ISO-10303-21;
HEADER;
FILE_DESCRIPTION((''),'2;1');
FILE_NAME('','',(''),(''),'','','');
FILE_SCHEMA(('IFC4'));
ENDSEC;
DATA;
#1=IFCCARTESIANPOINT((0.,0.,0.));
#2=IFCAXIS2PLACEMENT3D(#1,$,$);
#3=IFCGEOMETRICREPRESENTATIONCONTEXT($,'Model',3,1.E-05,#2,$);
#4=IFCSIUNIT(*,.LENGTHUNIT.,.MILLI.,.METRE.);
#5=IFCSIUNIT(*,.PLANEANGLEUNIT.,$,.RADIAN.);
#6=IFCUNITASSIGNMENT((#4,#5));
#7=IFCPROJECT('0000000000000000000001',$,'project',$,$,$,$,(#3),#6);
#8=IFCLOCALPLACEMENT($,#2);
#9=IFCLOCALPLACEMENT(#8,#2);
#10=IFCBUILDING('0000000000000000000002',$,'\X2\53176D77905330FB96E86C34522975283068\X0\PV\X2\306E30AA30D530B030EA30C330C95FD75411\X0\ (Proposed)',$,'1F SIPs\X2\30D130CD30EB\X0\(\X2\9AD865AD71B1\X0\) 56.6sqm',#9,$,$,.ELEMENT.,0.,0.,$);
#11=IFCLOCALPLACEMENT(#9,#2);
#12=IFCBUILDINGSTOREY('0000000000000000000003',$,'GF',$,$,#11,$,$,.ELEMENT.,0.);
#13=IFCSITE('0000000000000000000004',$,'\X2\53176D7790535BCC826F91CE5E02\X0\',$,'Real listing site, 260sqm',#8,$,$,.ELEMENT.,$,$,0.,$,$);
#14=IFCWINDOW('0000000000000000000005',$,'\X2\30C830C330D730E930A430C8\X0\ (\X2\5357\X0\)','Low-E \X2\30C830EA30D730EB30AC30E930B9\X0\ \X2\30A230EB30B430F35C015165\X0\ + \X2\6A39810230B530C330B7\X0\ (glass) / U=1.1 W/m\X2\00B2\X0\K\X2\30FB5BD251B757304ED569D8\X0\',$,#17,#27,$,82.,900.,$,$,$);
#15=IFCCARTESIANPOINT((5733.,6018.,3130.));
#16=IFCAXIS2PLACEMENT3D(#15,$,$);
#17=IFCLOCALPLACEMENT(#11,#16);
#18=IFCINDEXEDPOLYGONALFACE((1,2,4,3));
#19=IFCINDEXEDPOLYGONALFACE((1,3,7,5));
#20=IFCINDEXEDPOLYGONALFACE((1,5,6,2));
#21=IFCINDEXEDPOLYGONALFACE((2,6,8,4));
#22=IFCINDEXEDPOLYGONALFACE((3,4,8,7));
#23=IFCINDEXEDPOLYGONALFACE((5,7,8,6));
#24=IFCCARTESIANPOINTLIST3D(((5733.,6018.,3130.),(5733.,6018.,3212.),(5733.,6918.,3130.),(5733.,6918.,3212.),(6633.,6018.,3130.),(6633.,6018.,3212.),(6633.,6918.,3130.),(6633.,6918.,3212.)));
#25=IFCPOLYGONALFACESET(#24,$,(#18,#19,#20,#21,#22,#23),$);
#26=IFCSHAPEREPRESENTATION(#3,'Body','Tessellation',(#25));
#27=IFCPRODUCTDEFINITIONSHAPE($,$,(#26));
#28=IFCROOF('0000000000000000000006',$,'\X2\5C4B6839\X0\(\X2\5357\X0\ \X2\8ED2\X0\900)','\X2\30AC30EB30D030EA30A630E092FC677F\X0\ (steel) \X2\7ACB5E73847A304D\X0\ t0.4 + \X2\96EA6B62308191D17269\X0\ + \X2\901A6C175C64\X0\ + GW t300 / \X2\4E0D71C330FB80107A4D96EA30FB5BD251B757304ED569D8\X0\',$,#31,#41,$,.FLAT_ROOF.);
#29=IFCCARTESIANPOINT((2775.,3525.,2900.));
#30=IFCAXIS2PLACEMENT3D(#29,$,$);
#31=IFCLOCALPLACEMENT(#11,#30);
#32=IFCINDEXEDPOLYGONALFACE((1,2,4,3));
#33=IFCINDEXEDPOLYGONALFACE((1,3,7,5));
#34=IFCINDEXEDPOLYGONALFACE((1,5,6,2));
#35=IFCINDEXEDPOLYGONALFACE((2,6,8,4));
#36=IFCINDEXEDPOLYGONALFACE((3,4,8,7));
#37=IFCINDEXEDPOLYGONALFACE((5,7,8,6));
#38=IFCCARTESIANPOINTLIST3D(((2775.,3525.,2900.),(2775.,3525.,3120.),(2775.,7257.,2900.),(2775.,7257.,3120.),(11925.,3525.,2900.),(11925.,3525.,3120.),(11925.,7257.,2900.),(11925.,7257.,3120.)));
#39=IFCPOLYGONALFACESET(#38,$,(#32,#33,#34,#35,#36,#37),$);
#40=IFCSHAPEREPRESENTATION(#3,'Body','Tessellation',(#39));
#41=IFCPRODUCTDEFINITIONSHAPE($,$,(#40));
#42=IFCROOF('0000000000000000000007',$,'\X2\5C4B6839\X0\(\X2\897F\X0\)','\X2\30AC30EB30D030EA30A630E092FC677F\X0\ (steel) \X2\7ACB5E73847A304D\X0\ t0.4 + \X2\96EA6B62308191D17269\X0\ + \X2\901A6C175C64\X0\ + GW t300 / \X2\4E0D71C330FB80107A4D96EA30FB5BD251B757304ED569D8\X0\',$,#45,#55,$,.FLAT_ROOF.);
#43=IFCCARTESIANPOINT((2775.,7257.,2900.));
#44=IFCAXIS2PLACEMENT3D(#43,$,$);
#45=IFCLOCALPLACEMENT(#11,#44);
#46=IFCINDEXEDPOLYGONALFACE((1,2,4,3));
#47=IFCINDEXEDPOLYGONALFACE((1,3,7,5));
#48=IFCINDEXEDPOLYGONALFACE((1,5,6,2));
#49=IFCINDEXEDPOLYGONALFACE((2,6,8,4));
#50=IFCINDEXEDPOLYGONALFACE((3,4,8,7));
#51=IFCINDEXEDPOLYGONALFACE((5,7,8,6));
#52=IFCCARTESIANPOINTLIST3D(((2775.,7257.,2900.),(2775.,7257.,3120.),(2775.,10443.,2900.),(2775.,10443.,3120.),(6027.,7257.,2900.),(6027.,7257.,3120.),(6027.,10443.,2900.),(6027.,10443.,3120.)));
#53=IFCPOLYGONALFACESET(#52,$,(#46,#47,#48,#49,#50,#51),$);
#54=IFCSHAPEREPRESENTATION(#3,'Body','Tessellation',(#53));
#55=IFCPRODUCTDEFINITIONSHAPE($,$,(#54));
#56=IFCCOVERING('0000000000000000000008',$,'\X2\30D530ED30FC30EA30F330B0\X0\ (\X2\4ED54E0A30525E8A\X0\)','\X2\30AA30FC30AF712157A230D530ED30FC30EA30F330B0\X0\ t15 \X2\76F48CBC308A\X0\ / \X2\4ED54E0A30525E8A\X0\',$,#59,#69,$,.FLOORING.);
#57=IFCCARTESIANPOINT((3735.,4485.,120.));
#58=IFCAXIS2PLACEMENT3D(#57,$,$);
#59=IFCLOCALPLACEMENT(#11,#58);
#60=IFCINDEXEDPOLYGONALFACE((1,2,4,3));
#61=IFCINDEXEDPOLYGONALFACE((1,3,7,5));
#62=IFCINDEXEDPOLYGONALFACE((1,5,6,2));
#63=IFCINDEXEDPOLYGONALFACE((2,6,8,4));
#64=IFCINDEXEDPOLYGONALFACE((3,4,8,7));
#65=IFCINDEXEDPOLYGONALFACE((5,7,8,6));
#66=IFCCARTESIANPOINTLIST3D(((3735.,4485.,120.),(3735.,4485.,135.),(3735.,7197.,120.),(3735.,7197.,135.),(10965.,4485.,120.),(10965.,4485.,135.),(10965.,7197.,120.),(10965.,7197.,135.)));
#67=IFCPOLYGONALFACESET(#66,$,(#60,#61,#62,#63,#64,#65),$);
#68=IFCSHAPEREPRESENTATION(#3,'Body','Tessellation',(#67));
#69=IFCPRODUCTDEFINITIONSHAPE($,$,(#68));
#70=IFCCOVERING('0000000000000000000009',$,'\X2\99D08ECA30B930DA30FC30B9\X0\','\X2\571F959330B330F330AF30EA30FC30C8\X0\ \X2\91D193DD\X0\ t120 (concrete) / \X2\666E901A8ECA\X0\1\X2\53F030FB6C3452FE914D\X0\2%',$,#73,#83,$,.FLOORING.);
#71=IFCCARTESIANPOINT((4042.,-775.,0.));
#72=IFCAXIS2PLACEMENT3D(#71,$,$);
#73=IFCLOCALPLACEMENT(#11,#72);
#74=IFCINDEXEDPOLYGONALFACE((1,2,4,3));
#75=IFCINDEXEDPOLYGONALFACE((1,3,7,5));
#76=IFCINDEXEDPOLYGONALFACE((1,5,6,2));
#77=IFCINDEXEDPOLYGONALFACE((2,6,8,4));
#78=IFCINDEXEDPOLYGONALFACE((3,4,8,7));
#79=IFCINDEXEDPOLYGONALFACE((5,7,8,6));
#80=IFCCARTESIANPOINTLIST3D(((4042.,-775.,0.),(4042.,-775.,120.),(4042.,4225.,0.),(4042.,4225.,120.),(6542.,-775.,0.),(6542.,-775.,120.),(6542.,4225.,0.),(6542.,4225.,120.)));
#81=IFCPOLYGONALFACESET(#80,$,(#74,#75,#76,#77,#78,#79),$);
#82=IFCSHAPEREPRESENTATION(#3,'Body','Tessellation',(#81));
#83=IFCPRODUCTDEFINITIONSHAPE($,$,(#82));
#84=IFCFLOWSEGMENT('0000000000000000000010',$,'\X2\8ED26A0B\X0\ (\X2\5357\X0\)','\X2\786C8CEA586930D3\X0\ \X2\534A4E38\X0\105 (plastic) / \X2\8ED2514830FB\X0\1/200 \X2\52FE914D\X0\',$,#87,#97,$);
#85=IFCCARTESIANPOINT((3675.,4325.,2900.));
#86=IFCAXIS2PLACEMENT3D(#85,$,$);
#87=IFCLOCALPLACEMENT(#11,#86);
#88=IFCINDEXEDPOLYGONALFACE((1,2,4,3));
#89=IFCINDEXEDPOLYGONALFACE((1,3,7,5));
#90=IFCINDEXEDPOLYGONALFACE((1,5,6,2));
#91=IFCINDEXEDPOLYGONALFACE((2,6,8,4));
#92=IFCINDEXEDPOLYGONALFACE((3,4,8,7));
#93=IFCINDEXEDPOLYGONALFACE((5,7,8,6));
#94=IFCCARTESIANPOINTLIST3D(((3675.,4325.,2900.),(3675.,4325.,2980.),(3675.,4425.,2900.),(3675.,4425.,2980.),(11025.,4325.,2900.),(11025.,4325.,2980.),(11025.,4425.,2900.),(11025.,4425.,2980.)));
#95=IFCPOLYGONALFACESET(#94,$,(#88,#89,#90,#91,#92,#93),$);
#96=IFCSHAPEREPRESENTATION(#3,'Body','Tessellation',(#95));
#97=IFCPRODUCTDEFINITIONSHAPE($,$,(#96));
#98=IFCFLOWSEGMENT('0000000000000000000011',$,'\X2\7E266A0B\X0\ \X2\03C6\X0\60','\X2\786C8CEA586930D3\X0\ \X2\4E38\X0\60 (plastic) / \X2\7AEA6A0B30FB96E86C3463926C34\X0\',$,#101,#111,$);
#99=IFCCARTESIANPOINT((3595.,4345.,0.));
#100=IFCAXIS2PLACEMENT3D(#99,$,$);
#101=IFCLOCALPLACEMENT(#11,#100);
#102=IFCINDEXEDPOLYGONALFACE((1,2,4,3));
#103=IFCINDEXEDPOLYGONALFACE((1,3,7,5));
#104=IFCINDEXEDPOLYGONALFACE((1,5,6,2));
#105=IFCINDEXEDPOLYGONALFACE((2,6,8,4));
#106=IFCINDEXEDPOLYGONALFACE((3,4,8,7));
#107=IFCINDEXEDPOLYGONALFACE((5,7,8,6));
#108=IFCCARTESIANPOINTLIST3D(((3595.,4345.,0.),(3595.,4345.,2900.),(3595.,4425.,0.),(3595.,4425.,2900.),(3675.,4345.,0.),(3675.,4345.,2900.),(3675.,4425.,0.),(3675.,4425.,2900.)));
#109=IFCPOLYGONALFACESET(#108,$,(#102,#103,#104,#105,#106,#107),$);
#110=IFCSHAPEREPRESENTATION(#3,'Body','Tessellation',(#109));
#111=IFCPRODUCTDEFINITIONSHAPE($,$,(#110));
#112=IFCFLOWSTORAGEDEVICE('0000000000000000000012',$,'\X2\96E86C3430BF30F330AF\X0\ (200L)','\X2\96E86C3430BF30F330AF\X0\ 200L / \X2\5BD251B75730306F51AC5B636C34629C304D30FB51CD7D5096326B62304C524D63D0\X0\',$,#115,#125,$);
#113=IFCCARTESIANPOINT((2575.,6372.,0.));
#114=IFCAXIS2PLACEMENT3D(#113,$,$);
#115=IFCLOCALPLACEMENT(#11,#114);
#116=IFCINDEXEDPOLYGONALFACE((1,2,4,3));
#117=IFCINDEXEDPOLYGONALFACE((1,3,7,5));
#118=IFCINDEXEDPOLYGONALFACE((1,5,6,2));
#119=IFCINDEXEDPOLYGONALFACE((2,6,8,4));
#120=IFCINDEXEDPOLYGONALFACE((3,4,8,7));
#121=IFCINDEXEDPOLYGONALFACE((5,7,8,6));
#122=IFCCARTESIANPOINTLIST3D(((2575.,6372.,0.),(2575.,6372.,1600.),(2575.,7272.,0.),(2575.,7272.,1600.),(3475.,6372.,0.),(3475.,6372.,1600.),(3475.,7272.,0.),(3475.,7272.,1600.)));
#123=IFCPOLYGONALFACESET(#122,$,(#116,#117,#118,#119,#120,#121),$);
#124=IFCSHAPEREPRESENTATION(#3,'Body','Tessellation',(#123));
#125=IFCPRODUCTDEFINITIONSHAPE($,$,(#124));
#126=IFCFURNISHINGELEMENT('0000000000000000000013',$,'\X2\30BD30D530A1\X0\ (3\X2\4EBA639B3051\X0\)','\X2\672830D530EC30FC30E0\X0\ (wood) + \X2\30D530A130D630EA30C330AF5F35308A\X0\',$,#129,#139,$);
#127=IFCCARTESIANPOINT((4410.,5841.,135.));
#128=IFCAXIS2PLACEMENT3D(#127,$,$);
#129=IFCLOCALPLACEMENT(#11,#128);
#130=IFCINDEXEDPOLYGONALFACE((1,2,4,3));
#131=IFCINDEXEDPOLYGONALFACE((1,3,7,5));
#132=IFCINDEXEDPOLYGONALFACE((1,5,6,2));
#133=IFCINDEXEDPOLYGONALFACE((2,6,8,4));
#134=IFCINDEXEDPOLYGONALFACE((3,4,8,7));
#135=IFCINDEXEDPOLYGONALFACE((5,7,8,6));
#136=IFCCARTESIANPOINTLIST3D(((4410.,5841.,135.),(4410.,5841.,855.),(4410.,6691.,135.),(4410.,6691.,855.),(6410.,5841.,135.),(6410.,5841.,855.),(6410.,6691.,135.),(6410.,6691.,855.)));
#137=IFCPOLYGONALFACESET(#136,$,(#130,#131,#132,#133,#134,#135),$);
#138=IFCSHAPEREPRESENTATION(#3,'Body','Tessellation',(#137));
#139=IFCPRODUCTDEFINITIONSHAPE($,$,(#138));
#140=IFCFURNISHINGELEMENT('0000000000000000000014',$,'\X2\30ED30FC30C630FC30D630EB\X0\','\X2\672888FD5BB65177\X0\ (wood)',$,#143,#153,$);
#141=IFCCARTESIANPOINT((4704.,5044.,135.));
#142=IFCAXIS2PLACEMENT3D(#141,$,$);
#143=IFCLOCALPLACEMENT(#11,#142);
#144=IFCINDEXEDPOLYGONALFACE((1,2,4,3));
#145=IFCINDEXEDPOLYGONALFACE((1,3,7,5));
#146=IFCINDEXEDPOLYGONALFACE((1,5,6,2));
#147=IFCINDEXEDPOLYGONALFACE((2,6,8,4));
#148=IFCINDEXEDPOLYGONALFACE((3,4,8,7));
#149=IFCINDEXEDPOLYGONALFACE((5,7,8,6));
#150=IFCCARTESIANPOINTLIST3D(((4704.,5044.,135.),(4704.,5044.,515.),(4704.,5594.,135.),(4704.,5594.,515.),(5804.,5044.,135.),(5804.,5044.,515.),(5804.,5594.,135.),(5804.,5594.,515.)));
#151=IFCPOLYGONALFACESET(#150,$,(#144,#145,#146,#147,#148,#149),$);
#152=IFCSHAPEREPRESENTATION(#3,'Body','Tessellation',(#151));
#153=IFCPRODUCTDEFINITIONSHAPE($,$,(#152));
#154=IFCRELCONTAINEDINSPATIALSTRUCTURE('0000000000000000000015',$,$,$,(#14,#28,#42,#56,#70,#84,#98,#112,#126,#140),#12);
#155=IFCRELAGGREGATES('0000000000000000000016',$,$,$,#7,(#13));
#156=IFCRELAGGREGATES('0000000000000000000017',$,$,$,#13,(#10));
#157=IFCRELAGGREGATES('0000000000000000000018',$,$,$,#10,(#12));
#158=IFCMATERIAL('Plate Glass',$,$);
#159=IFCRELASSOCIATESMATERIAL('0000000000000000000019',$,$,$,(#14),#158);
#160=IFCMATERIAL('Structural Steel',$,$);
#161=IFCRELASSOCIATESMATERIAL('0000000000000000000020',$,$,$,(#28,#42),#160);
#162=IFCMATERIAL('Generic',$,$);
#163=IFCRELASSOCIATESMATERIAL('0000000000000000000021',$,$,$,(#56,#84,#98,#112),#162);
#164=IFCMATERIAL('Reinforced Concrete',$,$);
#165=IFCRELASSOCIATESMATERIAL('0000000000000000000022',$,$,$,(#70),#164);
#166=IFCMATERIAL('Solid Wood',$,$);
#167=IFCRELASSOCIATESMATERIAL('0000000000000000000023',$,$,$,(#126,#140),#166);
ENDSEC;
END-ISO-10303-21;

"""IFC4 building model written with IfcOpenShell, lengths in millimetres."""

from ifc_helpers import new_model, si_unit, frame, frame_2d, origin, place, context, project, spatial, rectangle, extrude, material, element, save


model = new_model("IFC4")

# Units and contexts
model_context = context("Model", 3, precision=1e-05, world=origin())
ifc_project = project(units=[si_unit("LENGTHUNIT", "METRE", prefix="MILLI"), si_unit("PLANEANGLEUNIT", "RADIAN")], contexts=[model_context])

# Site, building, storey
site_placement = place(None, origin())
site = spatial("IfcSite", under=ifc_project, at=site_placement, Name="北海道富良野市", ObjectType="Real listing site, 260sqm", CompositionType="ELEMENT", RefElevation=0.0)
building_placement = place(site_placement, origin())
building = spatial("IfcBuilding", under=site, at=building_placement, Name="北海道・雨水利用とPVのオフグリッド志向 (Proposed)", ObjectType="1F SIPsパネル(高断熱) 56.6sqm", CompositionType="ELEMENT", ElevationOfRefHeight=0.0, ElevationOfTerrain=0.0)
storey_placement = place(building_placement, origin())
storey = spatial("IfcBuildingStorey", under=building, at=storey_placement, Name="GF", CompositionType="ELEMENT", Elevation=0.0)

# Shared definitions
ifc_material_1 = material(Name="Solid Wood")

# Shared definitions
ifc_material_2 = material(Name="Reinforced Concrete")

# Shared definitions
ifc_material_3 = material(Name="Plate Glass")

# Window
window_1_placement = place(storey_placement, frame((5733.0, 6018.0, 3130.0)))
element("IfcWindow", 1, at=window_1_placement, inside=storey, material=ifc_material_3, Name="トップライト (南)", Description="Low-E トリプルガラス アルゴン封入 + 樹脂サッシ (glass) / U=1.1 W/m²K・寒冷地仕様", OverallHeight=82.0, OverallWidth=900.0, context=model_context, shape_type="SweptSolid", body=[
    extrude(rectangle(XDim=900.0, YDim=900.0, at=frame_2d((450.0, 450.0))), frame((5733.0, 6018.0, 3130.0)), (0.0, 0.0, 1.0), 82.0),
])

# Roofs
ifc_material_4 = material(Name="Structural Steel")
roof_1_placement = place(storey_placement, frame((2775.0, 3525.0, 2900.0)))
element("IfcRoof", 2, at=roof_1_placement, inside=storey, material=ifc_material_4, Name="屋根(南 軒900)", Description="ガルバリウム鋼板 (steel) 立平葺き t0.4 + 雪止め金物 + 通気層 + GW t300 / 不燃・耐積雪・寒冷地仕様", PredefinedType="FLAT_ROOF", context=model_context, shape_type="SweptSolid", body=[
    extrude(rectangle(XDim=9150.0, YDim=3732.0, at=frame_2d((4575.0, 1866.0))), frame((2775.0, 3525.0, 2900.0)), (0.0, 0.0, 1.0), 220.0),
])
roof_2_placement = place(storey_placement, frame((2775.0, 7257.0, 2900.0)))
element("IfcRoof", 3, at=roof_2_placement, inside=storey, material=ifc_material_4, Name="屋根(西)", Description="ガルバリウム鋼板 (steel) 立平葺き t0.4 + 雪止め金物 + 通気層 + GW t300 / 不燃・耐積雪・寒冷地仕様", PredefinedType="FLAT_ROOF", context=model_context, shape_type="SweptSolid", body=[
    extrude(rectangle(XDim=3252.0, YDim=3186.0, at=frame_2d((1626.0, 1593.0))), frame((2775.0, 7257.0, 2900.0)), (0.0, 0.0, 1.0), 220.0),
])

# Coverings
ifc_material_5 = material(Name="Generic")
covering_1_placement = place(storey_placement, frame((3735.0, 4485.0, 120.0)))
element("IfcCovering", 4, at=covering_1_placement, inside=storey, material=ifc_material_5, Name="フローリング (仕上げ床)", Description="オーク無垢フローリング t15 直貼り / 仕上げ床", PredefinedType="FLOORING", context=model_context, shape_type="SweptSolid", body=[
    extrude(rectangle(XDim=7230.0, YDim=2712.0, at=frame_2d((3615.0, 1356.0))), frame((3735.0, 4485.0, 120.0)), (0.0, 0.0, 1.0), 15.0),
])
covering_2_placement = place(storey_placement, frame((4042.0, -775.0, 0.0)))
element("IfcCovering", 5, at=covering_2_placement, inside=storey, material=ifc_material_2, Name="駐車スペース", Description="土間コンクリート 金鏝 t120 (concrete) / 普通車1台・水勾配2%", PredefinedType="FLOORING", context=model_context, shape_type="SweptSolid", body=[
    extrude(rectangle(XDim=2500.0, YDim=5000.0, at=frame_2d((1250.0, 2500.0))), frame((4042.0, -775.0, 0.0)), (0.0, 0.0, 1.0), 120.0),
])

# Flow segments
flow_segment_1_placement = place(storey_placement, frame((3675.0, 4325.0, 2900.0)))
element("IfcFlowSegment", 6, at=flow_segment_1_placement, inside=storey, material=ifc_material_5, Name="軒樋 (南)", Description="硬質塩ビ 半丸105 (plastic) / 軒先・1/200 勾配", context=model_context, shape_type="SweptSolid", body=[
    extrude(rectangle(XDim=7350.0, YDim=100.0, at=frame_2d((3675.0, 50.0))), frame((3675.0, 4325.0, 2900.0)), (0.0, 0.0, 1.0), 80.0),
])
flow_segment_2_placement = place(storey_placement, frame((3595.0, 4345.0, 0.0)))
element("IfcFlowSegment", 7, at=flow_segment_2_placement, inside=storey, material=ifc_material_5, Name="縦樋 φ60", Description="硬質塩ビ 丸60 (plastic) / 竪樋・雨水排水", context=model_context, shape_type="SweptSolid", body=[
    extrude(rectangle(XDim=80.0, YDim=80.0, at=frame_2d((40.0, 40.0))), frame((3595.0, 4345.0, 0.0)), (0.0, 0.0, 1.0), 2900.0),
])

# Flow storage device
flow_storage_device_placement = place(storey_placement, frame((2575.0, 6372.0, 0.0)))
element("IfcFlowStorageDevice", 8, at=flow_storage_device_placement, inside=storey, material=ifc_material_5, Name="雨水タンク (200L)", Description="雨水タンク 200L / 寒冷地は冬季水抜き・凍結防止が前提", context=model_context, shape_type="SweptSolid", body=[
    extrude(rectangle(XDim=900.0, YDim=900.0, at=frame_2d((450.0, 450.0))), frame((2575.0, 6372.0, 0.0)), (0.0, 0.0, 1.0), 1600.0),
])

# Furnishing elements
furnishing_1_placement = place(storey_placement, frame((4410.0, 5841.0, 135.0)))
element("IfcFurnishingElement", 9, at=furnishing_1_placement, inside=storey, material=ifc_material_1, Name="ソファ (3人掛け)", Description="木フレーム (wood) + ファブリック張り", context=model_context, shape_type="SweptSolid", body=[
    extrude(rectangle(XDim=2000.0, YDim=850.0, at=frame_2d((1000.0, 425.0))), frame((4410.0, 5841.0, 135.0)), (0.0, 0.0, 1.0), 720.0),
])
furnishing_2_placement = place(storey_placement, frame((4704.0, 5044.0, 135.0)))
element("IfcFurnishingElement", 10, at=furnishing_2_placement, inside=storey, material=ifc_material_1, Name="ローテーブル", Description="木製家具 (wood)", context=model_context, shape_type="SweptSolid", body=[
    extrude(rectangle(XDim=1100.0, YDim=550.0, at=frame_2d((550.0, 275.0))), frame((4704.0, 5044.0, 135.0)), (0.0, 0.0, 1.0), 380.0),
])

save(model, "model.ifc")
